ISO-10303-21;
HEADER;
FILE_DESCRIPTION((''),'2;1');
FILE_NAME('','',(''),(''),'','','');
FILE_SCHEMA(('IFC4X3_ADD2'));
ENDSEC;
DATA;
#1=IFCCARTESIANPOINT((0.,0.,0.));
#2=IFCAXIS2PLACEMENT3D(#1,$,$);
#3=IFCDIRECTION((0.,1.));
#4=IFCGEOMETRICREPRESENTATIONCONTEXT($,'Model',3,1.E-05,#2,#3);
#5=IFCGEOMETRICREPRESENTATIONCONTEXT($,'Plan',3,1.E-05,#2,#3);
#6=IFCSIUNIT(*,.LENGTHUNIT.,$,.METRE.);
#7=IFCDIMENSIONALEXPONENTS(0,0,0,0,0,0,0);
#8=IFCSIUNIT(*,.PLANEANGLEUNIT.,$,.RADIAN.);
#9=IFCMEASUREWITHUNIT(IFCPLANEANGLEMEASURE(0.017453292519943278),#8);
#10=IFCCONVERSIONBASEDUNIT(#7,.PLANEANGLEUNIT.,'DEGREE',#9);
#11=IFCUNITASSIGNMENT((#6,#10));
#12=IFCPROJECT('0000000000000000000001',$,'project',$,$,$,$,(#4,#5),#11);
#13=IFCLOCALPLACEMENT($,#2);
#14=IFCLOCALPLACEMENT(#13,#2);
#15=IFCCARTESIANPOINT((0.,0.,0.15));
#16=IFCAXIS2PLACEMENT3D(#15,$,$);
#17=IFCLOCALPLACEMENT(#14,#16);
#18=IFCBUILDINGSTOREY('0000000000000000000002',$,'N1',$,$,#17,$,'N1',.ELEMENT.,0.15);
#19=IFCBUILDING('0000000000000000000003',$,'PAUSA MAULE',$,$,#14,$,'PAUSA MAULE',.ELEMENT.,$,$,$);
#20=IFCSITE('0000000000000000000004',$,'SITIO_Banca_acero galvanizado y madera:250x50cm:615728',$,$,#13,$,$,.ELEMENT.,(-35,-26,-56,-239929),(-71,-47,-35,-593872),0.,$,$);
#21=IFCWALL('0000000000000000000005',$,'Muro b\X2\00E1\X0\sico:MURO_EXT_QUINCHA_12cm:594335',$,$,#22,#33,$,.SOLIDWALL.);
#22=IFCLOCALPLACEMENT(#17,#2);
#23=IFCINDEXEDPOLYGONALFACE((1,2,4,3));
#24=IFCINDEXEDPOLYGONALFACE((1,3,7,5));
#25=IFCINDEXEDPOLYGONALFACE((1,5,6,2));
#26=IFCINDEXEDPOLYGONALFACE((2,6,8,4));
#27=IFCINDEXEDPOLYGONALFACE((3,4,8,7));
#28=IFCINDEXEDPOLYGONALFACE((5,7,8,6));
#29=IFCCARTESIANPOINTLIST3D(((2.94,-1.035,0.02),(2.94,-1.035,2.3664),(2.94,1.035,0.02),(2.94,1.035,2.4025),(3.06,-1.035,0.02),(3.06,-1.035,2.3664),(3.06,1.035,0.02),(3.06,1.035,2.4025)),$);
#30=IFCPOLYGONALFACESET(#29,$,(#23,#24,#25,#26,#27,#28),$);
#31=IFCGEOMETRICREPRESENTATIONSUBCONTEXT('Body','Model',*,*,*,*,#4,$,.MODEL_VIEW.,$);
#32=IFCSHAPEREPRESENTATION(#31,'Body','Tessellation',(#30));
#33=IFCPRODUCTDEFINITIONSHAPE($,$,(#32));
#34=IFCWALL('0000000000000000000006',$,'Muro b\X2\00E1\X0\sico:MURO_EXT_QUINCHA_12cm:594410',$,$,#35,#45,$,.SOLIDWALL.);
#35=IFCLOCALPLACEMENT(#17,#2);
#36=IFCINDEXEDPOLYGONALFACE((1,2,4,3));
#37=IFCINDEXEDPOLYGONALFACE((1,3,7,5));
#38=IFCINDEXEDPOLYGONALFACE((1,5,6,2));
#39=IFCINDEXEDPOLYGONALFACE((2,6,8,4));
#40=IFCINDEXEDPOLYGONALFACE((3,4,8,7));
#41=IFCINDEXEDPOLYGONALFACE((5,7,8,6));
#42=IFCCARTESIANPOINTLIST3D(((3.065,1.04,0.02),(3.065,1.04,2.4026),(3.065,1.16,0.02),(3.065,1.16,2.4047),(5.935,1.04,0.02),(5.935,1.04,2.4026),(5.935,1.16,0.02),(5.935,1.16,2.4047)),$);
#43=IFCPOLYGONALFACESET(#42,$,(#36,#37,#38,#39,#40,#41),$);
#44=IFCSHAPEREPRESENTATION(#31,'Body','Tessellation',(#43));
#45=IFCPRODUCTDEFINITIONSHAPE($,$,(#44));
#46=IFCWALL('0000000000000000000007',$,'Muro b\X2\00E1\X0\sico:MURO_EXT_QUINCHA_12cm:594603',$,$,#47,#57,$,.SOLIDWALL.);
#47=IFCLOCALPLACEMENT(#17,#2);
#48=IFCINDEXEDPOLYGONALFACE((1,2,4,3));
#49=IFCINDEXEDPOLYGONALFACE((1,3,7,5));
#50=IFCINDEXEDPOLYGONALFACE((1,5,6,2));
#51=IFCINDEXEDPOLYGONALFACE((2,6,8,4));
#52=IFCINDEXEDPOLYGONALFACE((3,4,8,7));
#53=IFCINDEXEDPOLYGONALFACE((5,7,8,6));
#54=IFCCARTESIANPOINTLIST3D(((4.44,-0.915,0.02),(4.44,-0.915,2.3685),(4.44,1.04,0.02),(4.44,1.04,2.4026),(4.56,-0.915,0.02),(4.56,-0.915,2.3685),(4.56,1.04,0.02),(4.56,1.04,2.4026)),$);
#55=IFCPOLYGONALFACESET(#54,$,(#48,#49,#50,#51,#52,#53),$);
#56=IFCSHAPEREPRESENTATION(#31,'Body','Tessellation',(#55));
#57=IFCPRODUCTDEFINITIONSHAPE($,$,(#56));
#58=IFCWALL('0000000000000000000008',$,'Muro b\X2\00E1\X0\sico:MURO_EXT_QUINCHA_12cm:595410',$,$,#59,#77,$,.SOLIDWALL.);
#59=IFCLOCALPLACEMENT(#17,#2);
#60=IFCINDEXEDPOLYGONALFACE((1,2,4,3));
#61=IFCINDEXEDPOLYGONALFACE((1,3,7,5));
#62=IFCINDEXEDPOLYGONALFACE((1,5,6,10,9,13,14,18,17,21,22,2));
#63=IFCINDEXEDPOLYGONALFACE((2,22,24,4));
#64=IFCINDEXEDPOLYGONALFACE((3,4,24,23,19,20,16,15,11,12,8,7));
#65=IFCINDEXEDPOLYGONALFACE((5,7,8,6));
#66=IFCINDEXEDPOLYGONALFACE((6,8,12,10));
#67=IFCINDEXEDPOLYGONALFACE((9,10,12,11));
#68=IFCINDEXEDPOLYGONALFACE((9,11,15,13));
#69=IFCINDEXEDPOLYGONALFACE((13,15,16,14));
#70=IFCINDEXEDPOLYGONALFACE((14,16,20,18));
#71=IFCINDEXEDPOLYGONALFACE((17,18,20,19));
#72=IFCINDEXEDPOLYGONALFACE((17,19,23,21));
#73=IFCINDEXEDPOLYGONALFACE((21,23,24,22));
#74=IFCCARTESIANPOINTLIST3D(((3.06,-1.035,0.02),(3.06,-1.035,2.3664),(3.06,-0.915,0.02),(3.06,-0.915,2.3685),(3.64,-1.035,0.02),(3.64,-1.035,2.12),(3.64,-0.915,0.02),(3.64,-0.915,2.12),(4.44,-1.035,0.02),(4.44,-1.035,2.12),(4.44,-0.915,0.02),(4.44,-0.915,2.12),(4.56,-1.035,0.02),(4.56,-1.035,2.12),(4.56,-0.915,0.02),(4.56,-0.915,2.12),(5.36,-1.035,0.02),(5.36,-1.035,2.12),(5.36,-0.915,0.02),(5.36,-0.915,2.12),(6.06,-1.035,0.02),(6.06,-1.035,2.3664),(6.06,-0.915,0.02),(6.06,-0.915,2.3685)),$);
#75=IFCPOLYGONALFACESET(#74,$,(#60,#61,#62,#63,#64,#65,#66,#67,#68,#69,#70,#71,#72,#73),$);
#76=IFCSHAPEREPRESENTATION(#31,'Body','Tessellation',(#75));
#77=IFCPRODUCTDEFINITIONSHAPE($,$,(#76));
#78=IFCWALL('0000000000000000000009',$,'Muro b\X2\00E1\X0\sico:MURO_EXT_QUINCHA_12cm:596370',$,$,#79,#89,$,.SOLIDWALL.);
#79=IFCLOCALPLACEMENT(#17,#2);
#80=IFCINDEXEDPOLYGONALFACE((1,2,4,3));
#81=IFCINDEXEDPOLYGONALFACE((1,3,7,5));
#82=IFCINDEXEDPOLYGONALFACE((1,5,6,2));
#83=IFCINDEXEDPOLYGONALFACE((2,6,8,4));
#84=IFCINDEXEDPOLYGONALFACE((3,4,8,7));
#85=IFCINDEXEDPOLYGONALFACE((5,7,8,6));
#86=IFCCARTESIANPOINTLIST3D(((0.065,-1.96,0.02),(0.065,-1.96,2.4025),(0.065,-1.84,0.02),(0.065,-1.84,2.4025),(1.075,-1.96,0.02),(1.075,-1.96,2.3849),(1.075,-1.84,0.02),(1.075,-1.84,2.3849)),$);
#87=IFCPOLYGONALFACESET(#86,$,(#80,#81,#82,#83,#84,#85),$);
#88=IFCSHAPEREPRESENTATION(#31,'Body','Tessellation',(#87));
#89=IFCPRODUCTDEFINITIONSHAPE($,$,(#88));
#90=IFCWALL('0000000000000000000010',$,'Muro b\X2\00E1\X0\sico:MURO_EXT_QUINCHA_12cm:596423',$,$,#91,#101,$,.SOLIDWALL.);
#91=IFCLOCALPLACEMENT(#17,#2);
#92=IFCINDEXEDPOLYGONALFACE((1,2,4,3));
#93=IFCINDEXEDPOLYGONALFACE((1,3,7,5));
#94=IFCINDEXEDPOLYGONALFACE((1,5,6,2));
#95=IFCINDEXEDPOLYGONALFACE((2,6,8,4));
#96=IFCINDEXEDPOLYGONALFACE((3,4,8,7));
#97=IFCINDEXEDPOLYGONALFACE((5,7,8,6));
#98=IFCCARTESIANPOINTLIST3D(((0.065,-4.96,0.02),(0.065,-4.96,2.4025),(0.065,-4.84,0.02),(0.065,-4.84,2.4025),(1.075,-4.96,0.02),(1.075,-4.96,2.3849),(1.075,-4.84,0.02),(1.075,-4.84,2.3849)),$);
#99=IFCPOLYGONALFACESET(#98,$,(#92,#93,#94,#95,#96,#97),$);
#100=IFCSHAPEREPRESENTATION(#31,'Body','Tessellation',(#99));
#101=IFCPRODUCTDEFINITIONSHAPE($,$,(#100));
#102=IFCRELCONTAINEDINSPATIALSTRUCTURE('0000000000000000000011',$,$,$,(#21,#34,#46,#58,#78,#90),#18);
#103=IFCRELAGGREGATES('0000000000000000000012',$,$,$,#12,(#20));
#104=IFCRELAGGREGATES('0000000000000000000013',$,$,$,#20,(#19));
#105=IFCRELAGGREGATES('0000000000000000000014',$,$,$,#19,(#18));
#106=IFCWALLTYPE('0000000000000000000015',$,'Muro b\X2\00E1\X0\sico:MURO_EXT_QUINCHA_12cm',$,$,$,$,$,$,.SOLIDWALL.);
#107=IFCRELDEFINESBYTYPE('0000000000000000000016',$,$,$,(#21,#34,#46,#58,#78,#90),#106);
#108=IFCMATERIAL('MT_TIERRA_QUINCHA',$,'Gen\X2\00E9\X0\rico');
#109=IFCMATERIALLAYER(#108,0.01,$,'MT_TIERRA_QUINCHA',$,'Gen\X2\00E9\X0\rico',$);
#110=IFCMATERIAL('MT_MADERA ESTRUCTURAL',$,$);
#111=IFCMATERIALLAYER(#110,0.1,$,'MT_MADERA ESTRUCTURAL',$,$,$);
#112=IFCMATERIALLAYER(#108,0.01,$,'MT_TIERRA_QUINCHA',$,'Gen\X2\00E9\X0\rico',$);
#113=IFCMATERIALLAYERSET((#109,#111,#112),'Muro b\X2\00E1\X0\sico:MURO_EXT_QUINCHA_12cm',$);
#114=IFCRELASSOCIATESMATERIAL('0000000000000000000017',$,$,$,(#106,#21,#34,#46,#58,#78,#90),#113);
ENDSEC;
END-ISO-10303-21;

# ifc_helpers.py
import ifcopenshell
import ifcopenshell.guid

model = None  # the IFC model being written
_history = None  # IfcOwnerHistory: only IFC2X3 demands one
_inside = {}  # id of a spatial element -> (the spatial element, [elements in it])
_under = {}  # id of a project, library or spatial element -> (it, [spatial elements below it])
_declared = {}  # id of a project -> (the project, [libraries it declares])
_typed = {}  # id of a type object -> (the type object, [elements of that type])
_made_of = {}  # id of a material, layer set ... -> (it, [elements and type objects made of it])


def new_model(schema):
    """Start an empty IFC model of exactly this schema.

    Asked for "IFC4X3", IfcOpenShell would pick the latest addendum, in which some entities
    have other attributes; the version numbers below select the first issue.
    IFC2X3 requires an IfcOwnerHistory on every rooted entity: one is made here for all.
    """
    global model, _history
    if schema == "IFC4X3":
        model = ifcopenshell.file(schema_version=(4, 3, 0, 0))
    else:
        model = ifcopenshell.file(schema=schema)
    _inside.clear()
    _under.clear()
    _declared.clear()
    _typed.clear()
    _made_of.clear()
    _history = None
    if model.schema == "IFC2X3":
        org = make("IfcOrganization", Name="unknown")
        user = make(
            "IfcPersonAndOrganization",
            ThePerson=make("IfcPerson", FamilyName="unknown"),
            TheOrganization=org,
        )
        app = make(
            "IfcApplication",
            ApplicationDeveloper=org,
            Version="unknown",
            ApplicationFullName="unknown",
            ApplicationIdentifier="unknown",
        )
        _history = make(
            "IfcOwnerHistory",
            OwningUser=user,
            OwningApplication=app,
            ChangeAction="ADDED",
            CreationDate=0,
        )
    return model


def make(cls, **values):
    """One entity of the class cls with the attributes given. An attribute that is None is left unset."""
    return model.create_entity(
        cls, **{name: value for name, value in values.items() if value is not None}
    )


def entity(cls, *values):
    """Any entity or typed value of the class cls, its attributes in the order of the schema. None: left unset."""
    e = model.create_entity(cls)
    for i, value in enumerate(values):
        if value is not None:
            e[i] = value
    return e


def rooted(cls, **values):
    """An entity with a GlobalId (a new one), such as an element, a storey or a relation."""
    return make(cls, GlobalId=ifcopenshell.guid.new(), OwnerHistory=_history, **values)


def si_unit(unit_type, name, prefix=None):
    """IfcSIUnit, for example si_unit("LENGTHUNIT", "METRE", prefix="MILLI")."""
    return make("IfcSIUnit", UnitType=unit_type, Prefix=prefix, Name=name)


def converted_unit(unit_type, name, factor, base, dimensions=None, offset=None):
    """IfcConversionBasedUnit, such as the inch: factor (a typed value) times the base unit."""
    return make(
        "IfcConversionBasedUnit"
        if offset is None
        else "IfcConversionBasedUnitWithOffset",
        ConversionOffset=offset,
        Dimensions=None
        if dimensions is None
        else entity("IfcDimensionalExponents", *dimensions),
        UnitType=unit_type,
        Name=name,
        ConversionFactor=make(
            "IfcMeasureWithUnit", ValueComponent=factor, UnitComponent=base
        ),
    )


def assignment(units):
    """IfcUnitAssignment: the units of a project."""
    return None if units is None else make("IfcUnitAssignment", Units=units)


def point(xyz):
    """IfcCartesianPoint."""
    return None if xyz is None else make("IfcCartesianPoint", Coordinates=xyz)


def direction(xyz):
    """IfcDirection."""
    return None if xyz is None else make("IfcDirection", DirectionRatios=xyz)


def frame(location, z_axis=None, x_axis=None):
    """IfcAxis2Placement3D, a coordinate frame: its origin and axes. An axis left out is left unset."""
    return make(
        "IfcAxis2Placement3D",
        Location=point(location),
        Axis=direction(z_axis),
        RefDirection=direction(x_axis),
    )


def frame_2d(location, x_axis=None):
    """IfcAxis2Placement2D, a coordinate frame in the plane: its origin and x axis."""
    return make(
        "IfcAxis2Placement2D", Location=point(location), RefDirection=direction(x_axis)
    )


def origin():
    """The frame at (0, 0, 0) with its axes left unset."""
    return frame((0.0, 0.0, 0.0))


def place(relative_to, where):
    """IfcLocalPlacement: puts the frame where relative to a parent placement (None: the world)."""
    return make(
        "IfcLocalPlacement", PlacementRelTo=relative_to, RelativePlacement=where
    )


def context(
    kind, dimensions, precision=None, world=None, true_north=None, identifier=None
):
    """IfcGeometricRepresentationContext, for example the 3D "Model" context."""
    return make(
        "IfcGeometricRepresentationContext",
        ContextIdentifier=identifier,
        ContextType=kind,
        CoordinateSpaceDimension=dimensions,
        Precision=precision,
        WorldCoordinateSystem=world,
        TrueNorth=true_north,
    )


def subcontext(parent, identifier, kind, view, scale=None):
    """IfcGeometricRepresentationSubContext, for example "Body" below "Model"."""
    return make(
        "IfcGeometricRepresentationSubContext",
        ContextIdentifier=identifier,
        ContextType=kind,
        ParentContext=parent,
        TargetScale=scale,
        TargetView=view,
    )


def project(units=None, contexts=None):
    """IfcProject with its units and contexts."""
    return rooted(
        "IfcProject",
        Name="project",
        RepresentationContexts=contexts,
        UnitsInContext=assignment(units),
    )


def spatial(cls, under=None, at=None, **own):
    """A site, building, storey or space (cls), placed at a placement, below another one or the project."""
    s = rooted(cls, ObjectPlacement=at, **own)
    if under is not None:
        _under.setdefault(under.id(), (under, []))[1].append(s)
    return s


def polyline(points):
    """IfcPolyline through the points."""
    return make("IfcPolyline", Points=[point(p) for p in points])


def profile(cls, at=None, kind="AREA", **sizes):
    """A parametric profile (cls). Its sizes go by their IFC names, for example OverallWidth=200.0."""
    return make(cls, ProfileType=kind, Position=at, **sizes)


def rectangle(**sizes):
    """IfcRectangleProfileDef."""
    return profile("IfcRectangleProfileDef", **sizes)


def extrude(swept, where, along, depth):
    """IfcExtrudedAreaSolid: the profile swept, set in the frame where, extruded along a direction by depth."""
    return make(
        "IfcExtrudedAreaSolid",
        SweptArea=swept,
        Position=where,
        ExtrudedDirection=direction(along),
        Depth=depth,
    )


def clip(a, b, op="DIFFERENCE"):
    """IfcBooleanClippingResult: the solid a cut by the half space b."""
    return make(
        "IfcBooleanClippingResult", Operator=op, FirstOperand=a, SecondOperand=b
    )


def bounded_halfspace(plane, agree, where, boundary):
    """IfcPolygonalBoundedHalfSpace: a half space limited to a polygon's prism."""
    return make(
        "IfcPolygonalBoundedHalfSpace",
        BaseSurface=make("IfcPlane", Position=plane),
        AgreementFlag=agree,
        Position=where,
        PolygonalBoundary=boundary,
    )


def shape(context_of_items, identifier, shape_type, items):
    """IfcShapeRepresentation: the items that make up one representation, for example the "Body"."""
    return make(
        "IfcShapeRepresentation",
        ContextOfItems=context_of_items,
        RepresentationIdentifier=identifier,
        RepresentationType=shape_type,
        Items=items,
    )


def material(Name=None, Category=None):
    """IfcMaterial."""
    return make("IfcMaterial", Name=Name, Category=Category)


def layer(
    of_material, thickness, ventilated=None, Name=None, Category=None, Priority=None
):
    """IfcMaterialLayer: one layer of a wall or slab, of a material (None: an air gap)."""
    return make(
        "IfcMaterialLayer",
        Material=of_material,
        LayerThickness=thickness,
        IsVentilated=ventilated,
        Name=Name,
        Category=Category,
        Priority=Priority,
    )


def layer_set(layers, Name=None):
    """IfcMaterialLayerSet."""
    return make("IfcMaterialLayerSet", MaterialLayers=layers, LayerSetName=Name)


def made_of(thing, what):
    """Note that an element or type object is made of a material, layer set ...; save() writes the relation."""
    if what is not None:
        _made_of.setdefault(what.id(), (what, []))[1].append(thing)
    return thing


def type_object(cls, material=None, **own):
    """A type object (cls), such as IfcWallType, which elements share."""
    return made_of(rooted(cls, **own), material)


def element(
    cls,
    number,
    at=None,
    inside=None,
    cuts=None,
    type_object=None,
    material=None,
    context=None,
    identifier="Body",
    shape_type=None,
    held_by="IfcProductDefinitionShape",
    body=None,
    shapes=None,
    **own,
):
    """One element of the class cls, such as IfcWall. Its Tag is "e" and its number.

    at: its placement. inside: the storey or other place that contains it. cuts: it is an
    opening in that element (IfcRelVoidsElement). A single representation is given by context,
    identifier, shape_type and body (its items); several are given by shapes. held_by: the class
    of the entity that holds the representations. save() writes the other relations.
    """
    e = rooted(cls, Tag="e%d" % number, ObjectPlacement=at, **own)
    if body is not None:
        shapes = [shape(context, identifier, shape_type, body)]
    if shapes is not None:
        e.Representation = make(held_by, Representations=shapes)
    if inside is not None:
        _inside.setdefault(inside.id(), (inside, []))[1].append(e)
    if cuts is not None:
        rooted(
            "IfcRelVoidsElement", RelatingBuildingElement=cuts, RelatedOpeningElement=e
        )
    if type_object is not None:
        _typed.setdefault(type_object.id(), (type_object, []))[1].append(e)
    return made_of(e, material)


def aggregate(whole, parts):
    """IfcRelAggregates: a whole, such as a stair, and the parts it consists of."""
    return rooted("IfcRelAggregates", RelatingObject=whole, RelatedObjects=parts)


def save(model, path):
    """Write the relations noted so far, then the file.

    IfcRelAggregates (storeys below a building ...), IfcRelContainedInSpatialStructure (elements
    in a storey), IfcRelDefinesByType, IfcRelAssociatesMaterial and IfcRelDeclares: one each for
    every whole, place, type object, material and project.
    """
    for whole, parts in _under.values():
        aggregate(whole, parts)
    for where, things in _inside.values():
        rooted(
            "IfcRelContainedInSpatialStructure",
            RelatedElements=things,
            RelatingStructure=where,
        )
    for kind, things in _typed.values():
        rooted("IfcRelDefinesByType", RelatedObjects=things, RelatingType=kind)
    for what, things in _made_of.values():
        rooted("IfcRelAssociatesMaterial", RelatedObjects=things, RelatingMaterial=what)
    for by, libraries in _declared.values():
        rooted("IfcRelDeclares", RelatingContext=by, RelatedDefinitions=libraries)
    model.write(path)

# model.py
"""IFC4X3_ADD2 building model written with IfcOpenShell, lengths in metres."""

from ifc_helpers import new_model, entity, si_unit, converted_unit, direction, frame, frame_2d, origin, place, context, subcontext, project, spatial, polyline, rectangle, extrude, clip, bounded_halfspace, material, layer, layer_set, type_object, element, save


model = new_model("IFC4X3_ADD2")

# Units and contexts
model_context = context("Model", 3, precision=1e-05, world=origin(), true_north=direction((0.0, 1.0)))
plan_context = context("Plan", 3, precision=1e-05, world=origin(), true_north=direction((0.0, 1.0)))
body_context = subcontext(model_context, "Body", "Model", "MODEL_VIEW")
ifc_project = project(units=[si_unit("LENGTHUNIT", "METRE"), converted_unit("PLANEANGLEUNIT", "DEGREE", entity("IfcPlaneAngleMeasure", 0.017453292519943278), si_unit("PLANEANGLEUNIT", "RADIAN"), dimensions=[0, 0, 0, 0, 0, 0, 0])], contexts=[model_context, plan_context])

# Site, building, storey
site_placement = place(None, origin())
site = spatial("IfcSite", under=ifc_project, at=site_placement, Name="SITIO_Banca_acero galvanizado y madera:250x50cm:615728", CompositionType="ELEMENT", RefLatitude=(-35, -26, -56, -239929), RefLongitude=(-71, -47, -35, -593872), RefElevation=0.0)
building_placement = place(site_placement, origin())
building = spatial("IfcBuilding", under=site, at=building_placement, Name="PAUSA MAULE", LongName="PAUSA MAULE", CompositionType="ELEMENT")
storey_placement = place(building_placement, frame((0.0, 0.0, 0.15)))
storey = spatial("IfcBuildingStorey", under=building, at=storey_placement, Name="N1", LongName="N1", CompositionType="ELEMENT", Elevation=0.15)

# Walls
ifc_material_1 = material(Name="MT_TIERRA_QUINCHA", Category="Genérico")
ifc_layer_1 = layer(ifc_material_1, 0.01, Name="MT_TIERRA_QUINCHA", Category="Genérico")
ifc_material_2 = material(Name="MT_MADERA ESTRUCTURAL")
ifc_layer_2 = layer(ifc_material_2, 0.1, Name="MT_MADERA ESTRUCTURAL")
ifc_layer_3 = layer(ifc_material_1, 0.01, Name="MT_TIERRA_QUINCHA", Category="Genérico")
ifc_layer_set_1 = layer_set([ifc_layer_1, ifc_layer_2, ifc_layer_3], Name="Muro básico:MURO_EXT_QUINCHA_12cm")
wall_type = type_object("IfcWallType", Name="Muro básico:MURO_EXT_QUINCHA_12cm", PredefinedType="SOLIDWALL", material=ifc_layer_set_1)
wall_1_placement = place(storey_placement, frame((3.0, 1.035, 0.02), z_axis=(0.0, 0.0, 1.0), x_axis=(0.0, -1.0, 0.0)))
element("IfcWall", 1, at=wall_1_placement, inside=storey, type_object=wall_type, material=ifc_layer_set_1, Name="Muro básico:MURO_EXT_QUINCHA_12cm:594335", PredefinedType="SOLIDWALL", context=body_context, shape_type="Clipping", body=[
    clip(extrude(rectangle(XDim=2.07, YDim=0.12, at=frame_2d((1.035, 0.0), x_axis=(-1.0, 0.0))), origin(), (0.0, 0.0, 1.0), 2.3825), bounded_halfspace(frame((0.0, -0.06, 2.3825), z_axis=(0.017452, 0.0, 0.999848), x_axis=(0.0, 1.0, 0.0)), False, frame((0.0, -0.06, 2.3825)), polyline([(0.0, 0.0), (2.07, 0.0), (2.07, 0.12), (1.95, 0.12), (0.0, 0.12), (0.0, 0.0)]))),
])
wall_2_placement = place(storey_placement, frame((3.065, 1.1, 0.02)))
element("IfcWall", 2, at=wall_2_placement, inside=storey, type_object=wall_type, material=ifc_layer_set_1, Name="Muro básico:MURO_EXT_QUINCHA_12cm:594410", PredefinedType="SOLIDWALL", context=body_context, shape_type="Clipping", body=[
    clip(extrude(rectangle(XDim=2.87, YDim=0.12, at=frame_2d((1.435, 0.0), x_axis=(-1.0, 0.0))), origin(), (0.0, 0.0, 1.0), 2.3847), bounded_halfspace(frame((0.0, -0.06, 2.3826), z_axis=(0.0, -0.017452, 0.999848), x_axis=(1.0, 0.0, 0.0)), False, frame((0.0, -0.06, 2.3826)), polyline([(0.0, 0.0), (1.375, 0.0), (1.495, 0.0), (2.87, 0.0), (2.87, 0.12), (0.0, 0.12), (0.0, 0.0)]))),
])
wall_3_placement = place(storey_placement, frame((4.5, 1.04, 0.02), z_axis=(0.0, 0.0, 1.0), x_axis=(0.0, -1.0, 0.0)))
element("IfcWall", 3, at=wall_3_placement, inside=storey, type_object=wall_type, material=ifc_layer_set_1, Name="Muro básico:MURO_EXT_QUINCHA_12cm:594603", PredefinedType="SOLIDWALL", context=body_context, shape_type="Clipping", body=[
    clip(extrude(rectangle(XDim=1.955, YDim=0.12, at=frame_2d((0.9775, 0.0), x_axis=(-1.0, 0.0))), origin(), (0.0, 0.0, 1.0), 2.3826), bounded_halfspace(frame((0.0, -0.06, 2.3826), z_axis=(0.017452, 0.0, 0.999848), x_axis=(0.0, 1.0, 0.0)), False, frame((0.0, -0.06, 2.3826)), polyline([(0.0, 0.0), (1.955, 0.0), (1.955, 0.12), (0.0, 0.12), (0.0, 0.0)]))),
])

# Wall, openings
wall_4_placement = place(storey_placement, frame((3.06, -0.975, 0.02)))
wall_4 = element("IfcWall", 4, at=wall_4_placement, inside=storey, type_object=wall_type, material=ifc_layer_set_1, Name="Muro básico:MURO_EXT_QUINCHA_12cm:595410", PredefinedType="SOLIDWALL", context=body_context, shape_type="Clipping", body=[
    clip(extrude(rectangle(XDim=3.0, YDim=0.12, at=frame_2d((1.5, 0.0), x_axis=(1.0, 0.0))), origin(), (0.0, 0.0, 1.0), 2.3485), bounded_halfspace(frame((0.0, -0.06, 2.3464), z_axis=(0.0, -0.017452, 0.999848), x_axis=(1.0, 0.0, 0.0)), False, frame((0.0, -0.06, 2.3464)), polyline([(0.0, 0.0), (3.0, 0.0), (3.0, 0.12), (2.88, 0.12), (1.5, 0.12), (1.38, 0.12), (0.0, 0.12), (0.0, 0.0)]))),
])
opening_1_placement = place(wall_4_placement, frame((1.5, -0.06, 0.0)))
element("IfcOpeningElement", 5, at=opening_1_placement, cuts=wall_4, PredefinedType="OPENING", context=body_context, shape_type="SweptSolid", body=[
    extrude(rectangle(XDim=2.1, YDim=0.8, at=frame_2d((1.05, 0.4), x_axis=(1.0, 0.0))), frame((0.0, 0.0, 0.0), z_axis=(0.0, 1.0, 0.0), x_axis=(0.0, 0.0, 1.0)), (0.0, 0.0, 1.0), 0.12),
])
opening_2_placement = place(wall_4_placement, frame((0.58, -0.06, 0.0)))
element("IfcOpeningElement", 6, at=opening_2_placement, cuts=wall_4, PredefinedType="OPENING", context=body_context, shape_type="SweptSolid", body=[
    extrude(rectangle(XDim=2.1, YDim=0.8, at=frame_2d((1.05, 0.4), x_axis=(1.0, 0.0))), frame((0.0, 0.0, 0.0), z_axis=(0.0, 1.0, 0.0), x_axis=(0.0, 0.0, 1.0)), (0.0, 0.0, 1.0), 0.12),
])

# Walls
wall_5_placement = place(storey_placement, frame((0.065, -1.9, 0.02)))
element("IfcWall", 7, at=wall_5_placement, inside=storey, type_object=wall_type, material=ifc_layer_set_1, Name="Muro básico:MURO_EXT_QUINCHA_12cm:596370", PredefinedType="SOLIDWALL", context=body_context, shape_type="Clipping", body=[
    clip(extrude(rectangle(XDim=1.01, YDim=0.12, at=frame_2d((0.505, 0.0), x_axis=(-1.0, 0.0))), origin(), (0.0, 0.0, 1.0), 2.3825), bounded_halfspace(frame((0.0, -0.06, 2.3825), z_axis=(0.017452, 0.0, 0.999848), x_axis=(0.0, 1.0, 0.0)), False, frame((0.0, -0.06, 2.3825)), polyline([(0.0, 0.0), (1.01, 0.0), (1.01, 0.12), (0.0, 0.12), (0.0, 0.0)]))),
])
wall_6_placement = place(storey_placement, frame((0.065, -4.9, 0.02)))
element("IfcWall", 8, at=wall_6_placement, inside=storey, type_object=wall_type, material=ifc_layer_set_1, Name="Muro básico:MURO_EXT_QUINCHA_12cm:596423", PredefinedType="SOLIDWALL", context=body_context, shape_type="Clipping", body=[
    clip(extrude(rectangle(XDim=1.01, YDim=0.12, at=frame_2d((0.505, 0.0), x_axis=(-1.0, 0.0))), origin(), (0.0, 0.0, 1.0), 2.3825), bounded_halfspace(frame((0.0, -0.06, 2.3825), z_axis=(0.017452, 0.0, 0.999848), x_axis=(0.0, 1.0, 0.0)), False, frame((0.0, -0.06, 2.3825)), polyline([(0.0, 0.0), (1.01, 0.0), (1.01, 0.12), (0.0, 0.12), (0.0, 0.0)]))),
])

save(model, "model.ifc")
